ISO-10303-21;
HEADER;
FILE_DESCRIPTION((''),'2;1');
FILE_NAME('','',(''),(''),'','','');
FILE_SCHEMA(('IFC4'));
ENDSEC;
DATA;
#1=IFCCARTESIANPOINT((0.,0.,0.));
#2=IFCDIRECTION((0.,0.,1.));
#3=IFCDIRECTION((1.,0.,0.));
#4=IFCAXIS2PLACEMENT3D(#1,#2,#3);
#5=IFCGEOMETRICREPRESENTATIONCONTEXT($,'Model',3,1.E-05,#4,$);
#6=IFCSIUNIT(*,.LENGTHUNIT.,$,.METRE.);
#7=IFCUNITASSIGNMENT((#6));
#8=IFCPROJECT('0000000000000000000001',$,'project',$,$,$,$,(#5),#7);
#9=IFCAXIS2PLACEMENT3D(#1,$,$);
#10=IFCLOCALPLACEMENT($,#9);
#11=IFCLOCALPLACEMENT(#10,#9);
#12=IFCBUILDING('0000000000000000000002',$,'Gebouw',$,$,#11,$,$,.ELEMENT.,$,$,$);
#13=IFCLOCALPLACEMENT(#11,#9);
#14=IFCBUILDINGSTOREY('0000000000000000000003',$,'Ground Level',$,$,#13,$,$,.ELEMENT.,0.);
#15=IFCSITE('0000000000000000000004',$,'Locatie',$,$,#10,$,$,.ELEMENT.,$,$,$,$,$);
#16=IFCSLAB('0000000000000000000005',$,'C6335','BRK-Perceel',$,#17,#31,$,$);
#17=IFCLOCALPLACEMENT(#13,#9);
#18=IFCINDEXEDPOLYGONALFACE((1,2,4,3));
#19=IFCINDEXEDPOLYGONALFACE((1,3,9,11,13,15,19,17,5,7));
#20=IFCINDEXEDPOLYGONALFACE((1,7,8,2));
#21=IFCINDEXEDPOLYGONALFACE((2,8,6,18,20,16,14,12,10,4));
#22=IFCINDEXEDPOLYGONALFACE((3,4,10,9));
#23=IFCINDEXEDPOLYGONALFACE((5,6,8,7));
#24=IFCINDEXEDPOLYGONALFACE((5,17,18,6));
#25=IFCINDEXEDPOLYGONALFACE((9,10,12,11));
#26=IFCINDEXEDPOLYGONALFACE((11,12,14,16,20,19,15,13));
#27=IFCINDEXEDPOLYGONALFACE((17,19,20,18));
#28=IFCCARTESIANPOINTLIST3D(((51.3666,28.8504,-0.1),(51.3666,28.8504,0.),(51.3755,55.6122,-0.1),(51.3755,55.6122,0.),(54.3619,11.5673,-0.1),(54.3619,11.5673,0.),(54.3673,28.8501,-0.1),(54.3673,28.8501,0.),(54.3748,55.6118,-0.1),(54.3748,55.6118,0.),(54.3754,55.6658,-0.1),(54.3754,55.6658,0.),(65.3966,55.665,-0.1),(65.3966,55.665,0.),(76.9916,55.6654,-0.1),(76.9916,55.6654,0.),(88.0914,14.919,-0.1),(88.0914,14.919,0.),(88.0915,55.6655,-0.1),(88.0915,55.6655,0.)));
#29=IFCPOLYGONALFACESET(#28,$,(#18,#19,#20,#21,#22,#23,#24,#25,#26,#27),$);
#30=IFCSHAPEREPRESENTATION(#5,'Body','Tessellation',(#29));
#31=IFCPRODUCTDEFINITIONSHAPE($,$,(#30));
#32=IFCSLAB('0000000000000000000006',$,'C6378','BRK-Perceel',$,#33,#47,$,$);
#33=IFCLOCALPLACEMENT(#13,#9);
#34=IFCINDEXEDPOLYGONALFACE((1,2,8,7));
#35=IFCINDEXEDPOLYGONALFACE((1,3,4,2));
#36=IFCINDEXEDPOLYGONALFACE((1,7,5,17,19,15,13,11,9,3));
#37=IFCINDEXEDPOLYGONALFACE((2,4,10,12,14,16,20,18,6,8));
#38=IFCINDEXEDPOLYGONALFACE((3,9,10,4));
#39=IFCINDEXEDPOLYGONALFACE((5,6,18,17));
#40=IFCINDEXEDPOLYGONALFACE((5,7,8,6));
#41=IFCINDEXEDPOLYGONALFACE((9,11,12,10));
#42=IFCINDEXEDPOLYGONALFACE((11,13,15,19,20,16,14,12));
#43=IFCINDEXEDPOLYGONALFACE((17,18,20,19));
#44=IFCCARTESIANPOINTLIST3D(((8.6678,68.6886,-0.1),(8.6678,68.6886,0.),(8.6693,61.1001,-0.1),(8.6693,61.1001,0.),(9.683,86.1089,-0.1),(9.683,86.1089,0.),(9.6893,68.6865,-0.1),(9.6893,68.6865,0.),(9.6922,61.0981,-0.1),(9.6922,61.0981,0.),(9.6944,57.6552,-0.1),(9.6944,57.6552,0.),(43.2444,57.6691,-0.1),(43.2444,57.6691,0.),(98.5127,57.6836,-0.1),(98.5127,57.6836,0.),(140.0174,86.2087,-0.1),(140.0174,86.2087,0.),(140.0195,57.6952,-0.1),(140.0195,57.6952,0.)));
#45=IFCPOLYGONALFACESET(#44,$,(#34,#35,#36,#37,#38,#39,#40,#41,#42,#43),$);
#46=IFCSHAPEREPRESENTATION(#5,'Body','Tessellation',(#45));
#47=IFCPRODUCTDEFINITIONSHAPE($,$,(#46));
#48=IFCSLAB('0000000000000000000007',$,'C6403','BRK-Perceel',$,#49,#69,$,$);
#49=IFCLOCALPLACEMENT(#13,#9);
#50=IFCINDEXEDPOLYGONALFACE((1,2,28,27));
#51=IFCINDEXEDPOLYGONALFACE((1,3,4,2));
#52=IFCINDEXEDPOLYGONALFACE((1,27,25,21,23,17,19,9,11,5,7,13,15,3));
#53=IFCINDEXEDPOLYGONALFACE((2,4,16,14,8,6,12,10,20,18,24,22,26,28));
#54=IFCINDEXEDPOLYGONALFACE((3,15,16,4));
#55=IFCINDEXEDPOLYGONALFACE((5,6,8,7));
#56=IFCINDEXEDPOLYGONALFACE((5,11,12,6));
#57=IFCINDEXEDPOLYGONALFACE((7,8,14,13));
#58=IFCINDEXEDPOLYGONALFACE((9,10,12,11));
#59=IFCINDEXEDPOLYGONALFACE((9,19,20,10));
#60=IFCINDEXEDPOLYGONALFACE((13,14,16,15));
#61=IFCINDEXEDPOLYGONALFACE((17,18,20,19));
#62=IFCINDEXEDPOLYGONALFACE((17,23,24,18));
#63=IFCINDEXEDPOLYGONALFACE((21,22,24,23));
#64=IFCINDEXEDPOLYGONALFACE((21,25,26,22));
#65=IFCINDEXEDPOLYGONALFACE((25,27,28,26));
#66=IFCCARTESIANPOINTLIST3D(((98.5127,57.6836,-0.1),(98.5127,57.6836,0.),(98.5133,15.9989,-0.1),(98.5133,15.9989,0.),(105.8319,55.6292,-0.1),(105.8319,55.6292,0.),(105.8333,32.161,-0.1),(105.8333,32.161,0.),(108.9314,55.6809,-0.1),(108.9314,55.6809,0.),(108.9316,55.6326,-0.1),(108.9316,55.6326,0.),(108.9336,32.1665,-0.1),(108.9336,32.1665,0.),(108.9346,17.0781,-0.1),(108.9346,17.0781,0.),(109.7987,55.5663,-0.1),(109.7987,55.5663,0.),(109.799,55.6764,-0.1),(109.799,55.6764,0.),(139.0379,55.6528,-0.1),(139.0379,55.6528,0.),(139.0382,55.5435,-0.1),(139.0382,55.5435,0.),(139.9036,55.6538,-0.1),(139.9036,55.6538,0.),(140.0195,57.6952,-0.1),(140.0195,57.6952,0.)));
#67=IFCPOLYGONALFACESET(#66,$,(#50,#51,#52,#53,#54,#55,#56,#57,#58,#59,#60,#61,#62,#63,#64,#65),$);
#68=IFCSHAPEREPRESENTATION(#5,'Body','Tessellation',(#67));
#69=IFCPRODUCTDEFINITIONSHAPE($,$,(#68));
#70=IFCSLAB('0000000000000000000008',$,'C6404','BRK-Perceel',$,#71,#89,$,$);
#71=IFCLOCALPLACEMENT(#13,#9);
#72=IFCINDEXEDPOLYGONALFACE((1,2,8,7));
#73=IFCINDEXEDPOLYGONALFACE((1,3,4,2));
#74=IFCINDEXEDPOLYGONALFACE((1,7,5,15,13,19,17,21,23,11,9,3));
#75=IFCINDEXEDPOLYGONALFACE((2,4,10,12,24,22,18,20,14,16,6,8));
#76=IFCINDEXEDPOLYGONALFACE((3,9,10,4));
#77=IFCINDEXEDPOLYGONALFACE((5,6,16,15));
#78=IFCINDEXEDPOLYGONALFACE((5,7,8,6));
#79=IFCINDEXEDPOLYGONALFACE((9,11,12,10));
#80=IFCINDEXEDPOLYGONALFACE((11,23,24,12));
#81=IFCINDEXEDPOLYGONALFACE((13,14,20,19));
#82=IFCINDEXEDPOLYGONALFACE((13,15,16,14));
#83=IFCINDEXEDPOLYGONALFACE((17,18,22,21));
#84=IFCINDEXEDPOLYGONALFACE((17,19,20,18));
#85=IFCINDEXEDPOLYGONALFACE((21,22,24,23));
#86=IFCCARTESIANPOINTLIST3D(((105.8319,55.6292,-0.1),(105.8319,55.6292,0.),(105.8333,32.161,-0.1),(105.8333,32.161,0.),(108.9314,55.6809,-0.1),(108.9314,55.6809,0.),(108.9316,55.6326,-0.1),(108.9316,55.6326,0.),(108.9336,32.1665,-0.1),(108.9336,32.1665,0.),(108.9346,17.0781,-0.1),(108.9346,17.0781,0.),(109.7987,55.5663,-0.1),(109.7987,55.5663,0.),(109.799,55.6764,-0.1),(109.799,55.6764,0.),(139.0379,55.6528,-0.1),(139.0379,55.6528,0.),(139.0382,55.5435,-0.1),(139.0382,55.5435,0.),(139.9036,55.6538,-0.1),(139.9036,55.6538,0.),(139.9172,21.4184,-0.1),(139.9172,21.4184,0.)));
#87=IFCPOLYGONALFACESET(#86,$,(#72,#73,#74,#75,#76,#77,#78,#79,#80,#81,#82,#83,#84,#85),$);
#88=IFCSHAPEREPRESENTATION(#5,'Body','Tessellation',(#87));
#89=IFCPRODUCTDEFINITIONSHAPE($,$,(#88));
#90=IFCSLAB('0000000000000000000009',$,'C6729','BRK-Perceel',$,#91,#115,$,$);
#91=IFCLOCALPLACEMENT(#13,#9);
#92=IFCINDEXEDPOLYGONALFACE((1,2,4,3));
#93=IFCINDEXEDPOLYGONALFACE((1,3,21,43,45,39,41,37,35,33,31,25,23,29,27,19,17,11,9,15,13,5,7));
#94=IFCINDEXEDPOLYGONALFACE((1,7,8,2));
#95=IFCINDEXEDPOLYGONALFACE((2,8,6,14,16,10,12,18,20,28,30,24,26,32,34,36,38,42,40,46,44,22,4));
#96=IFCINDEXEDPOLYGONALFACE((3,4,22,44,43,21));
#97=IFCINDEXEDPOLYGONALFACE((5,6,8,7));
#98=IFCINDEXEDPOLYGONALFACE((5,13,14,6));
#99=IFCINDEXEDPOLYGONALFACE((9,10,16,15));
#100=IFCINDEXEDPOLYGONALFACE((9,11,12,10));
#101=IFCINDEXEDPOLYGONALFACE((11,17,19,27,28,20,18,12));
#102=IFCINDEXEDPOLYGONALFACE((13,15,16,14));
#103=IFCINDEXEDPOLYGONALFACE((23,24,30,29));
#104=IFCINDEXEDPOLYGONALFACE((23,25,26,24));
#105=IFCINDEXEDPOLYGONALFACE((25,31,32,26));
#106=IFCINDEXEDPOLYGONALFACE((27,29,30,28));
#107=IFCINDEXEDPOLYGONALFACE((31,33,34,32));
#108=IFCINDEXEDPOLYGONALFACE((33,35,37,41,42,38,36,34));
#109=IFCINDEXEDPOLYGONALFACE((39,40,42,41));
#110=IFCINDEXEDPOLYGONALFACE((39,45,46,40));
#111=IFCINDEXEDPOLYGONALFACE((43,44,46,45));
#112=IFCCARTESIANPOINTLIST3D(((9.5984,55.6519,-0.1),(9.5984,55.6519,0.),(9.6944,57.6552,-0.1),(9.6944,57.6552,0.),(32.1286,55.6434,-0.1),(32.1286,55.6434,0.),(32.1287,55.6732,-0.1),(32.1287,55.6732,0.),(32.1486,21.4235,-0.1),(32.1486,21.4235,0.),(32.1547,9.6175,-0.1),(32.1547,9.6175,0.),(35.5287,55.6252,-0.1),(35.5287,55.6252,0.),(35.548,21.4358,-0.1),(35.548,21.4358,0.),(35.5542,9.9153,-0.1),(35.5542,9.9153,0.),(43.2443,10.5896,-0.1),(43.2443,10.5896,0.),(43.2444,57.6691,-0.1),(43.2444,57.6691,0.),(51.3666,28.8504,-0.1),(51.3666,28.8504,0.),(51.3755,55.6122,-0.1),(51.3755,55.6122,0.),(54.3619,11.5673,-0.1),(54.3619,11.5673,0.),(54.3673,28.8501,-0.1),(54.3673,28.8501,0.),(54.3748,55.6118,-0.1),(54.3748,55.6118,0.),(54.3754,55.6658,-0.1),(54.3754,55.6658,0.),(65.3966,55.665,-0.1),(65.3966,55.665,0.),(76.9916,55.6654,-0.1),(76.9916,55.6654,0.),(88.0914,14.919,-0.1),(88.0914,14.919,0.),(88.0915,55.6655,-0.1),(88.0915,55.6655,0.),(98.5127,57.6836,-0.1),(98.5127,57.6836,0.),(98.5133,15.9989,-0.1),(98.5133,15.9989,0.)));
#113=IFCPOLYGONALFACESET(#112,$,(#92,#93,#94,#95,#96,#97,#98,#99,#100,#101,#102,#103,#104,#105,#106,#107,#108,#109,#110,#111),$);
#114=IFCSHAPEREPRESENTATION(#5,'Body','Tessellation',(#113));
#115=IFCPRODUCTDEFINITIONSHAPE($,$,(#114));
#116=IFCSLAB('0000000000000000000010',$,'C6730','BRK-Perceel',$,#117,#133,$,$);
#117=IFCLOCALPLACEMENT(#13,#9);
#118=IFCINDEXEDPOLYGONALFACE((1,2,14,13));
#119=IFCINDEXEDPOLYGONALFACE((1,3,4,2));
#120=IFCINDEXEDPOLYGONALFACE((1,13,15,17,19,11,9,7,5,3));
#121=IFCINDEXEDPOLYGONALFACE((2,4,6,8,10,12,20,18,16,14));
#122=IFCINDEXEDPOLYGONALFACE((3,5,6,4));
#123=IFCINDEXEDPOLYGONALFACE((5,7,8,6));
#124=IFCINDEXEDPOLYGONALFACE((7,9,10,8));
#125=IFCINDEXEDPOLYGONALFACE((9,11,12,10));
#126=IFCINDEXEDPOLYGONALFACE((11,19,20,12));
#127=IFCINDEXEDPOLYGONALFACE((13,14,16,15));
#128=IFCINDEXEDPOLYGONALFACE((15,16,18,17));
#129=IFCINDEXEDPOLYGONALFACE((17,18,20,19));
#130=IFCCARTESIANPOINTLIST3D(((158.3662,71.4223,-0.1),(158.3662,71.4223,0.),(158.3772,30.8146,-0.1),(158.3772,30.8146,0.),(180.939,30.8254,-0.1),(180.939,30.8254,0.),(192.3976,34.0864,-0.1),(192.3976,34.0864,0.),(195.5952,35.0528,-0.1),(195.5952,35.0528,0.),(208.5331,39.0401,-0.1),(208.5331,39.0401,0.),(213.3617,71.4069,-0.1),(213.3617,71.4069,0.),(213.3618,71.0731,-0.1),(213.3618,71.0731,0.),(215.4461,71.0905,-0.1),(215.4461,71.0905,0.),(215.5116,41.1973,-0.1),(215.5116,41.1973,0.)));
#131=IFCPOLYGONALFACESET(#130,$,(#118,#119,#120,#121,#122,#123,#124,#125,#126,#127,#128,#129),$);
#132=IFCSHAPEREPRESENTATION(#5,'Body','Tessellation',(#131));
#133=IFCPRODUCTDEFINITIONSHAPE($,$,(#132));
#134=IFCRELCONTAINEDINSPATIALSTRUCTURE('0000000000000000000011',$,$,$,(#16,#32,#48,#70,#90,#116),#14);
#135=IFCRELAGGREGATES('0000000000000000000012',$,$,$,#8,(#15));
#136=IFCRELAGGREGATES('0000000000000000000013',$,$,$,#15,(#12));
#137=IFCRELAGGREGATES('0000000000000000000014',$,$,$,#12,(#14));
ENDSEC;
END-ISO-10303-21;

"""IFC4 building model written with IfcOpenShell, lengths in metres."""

from ifc_helpers import new_model, si_unit, frame, origin, origin_with_axes, place, context, project, spatial, polyline, outline, extrude, element, save


model = new_model("IFC4")

# Units and contexts
model_context = context("Model", 3, precision=1e-05, world=origin_with_axes())
ifc_project = project(units=[si_unit("LENGTHUNIT", "METRE")], contexts=[model_context])

# Site, building, storey
site_placement = place(None, origin())
site = spatial("IfcSite", under=ifc_project, at=site_placement, Name="Locatie", CompositionType="ELEMENT")
building_placement = place(site_placement, origin())
building = spatial("IfcBuilding", under=site, at=building_placement, Name="Gebouw", CompositionType="ELEMENT")
storey_placement = place(building_placement, origin())
storey = spatial("IfcBuildingStorey", under=building, at=storey_placement, Name="Ground Level", CompositionType="ELEMENT", Elevation=0.0)

# Slabs
slab_1_placement = place(storey_placement, origin())
element("IfcSlab", 1, at=slab_1_placement, inside=storey, Name="C6335", Description="BRK-Perceel", context=model_context, shape_type="SweptSolid", body=[
    extrude(outline(polyline([(54.3748, 55.6118), (54.3754, 55.6658), (65.3966, 55.665), (76.9916, 55.6654), (88.0915, 55.6655), (88.0914, 14.919), (54.3619, 11.5673), (54.3673, 28.8501), (51.3666, 28.8504), (51.3755, 55.6122), (54.3748, 55.6118)])), frame((0.0, 0.0, -0.1), z_axis=(0.0, 0.0, 1.0), x_axis=(1.0, 0.0, 0.0)), (0.0, 0.0, 1.0), 0.1),
])
slab_2_placement = place(storey_placement, origin())
element("IfcSlab", 2, at=slab_2_placement, inside=storey, Name="C6378", Description="BRK-Perceel", context=model_context, shape_type="SweptSolid", body=[
    extrude(outline(polyline([(98.5127, 57.6836), (43.2444, 57.6691), (9.6944, 57.6552), (9.6922, 61.0981), (8.6693, 61.1001), (8.6678, 68.6886), (9.6893, 68.6865), (9.683, 86.1089), (140.0174, 86.2087), (140.0195, 57.6952), (98.5127, 57.6836)])), frame((0.0, 0.0, -0.1), z_axis=(0.0, 0.0, 1.0), x_axis=(1.0, 0.0, 0.0)), (0.0, 0.0, 1.0), 0.1),
])
slab_3_placement = place(storey_placement, origin())
element("IfcSlab", 3, at=slab_3_placement, inside=storey, Name="C6403", Description="BRK-Perceel", context=model_context, shape_type="SweptSolid", body=[
    extrude(outline(polyline([(98.5133, 15.9989), (98.5127, 57.6836), (140.0195, 57.6952), (139.9036, 55.6538), (139.0379, 55.6528), (139.0382, 55.5435), (109.7987, 55.5663), (109.799, 55.6764), (108.9314, 55.6809), (108.9316, 55.6326), (105.8319, 55.6292), (105.8333, 32.161), (108.9336, 32.1665), (108.9346, 17.0781), (98.5133, 15.9989)])), frame((0.0, 0.0, -0.1), z_axis=(0.0, 0.0, 1.0), x_axis=(1.0, 0.0, 0.0)), (0.0, 0.0, 1.0), 0.1),
])
slab_4_placement = place(storey_placement, origin())
element("IfcSlab", 4, at=slab_4_placement, inside=storey, Name="C6404", Description="BRK-Perceel", context=model_context, shape_type="SweptSolid", body=[
    extrude(outline(polyline([(108.9314, 55.6809), (109.799, 55.6764), (109.7987, 55.5663), (139.0382, 55.5435), (139.0379, 55.6528), (139.9036, 55.6538), (139.9172, 21.4184), (108.9346, 17.0781), (108.9336, 32.1665), (105.8333, 32.161), (105.8319, 55.6292), (108.9316, 55.6326), (108.9314, 55.6809)])), frame((0.0, 0.0, -0.1), z_axis=(0.0, 0.0, 1.0), x_axis=(1.0, 0.0, 0.0)), (0.0, 0.0, 1.0), 0.1),
])
slab_5_placement = place(storey_placement, origin())
element("IfcSlab", 5, at=slab_5_placement, inside=storey, Name="C6729", Description="BRK-Perceel", context=model_context, shape_type="SweptSolid", body=[
    extrude(outline(polyline([(43.2443, 10.5896), (35.5542, 9.9153), (32.1547, 9.6175), (32.1486, 21.4235), (35.548, 21.4358), (35.5287, 55.6252), (32.1286, 55.6434), (32.1287, 55.6732), (9.5984, 55.6519), (9.6944, 57.6552), (43.2444, 57.6691), (98.5127, 57.6836), (98.5133, 15.9989), (88.0914, 14.919), (88.0915, 55.6655), (76.9916, 55.6654), (65.3966, 55.665), (54.3754, 55.6658), (54.3748, 55.6118), (51.3755, 55.6122), (51.3666, 28.8504), (54.3673, 28.8501), (54.3619, 11.5673), (43.2443, 10.5896)])), frame((0.0, 0.0, -0.1), z_axis=(0.0, 0.0, 1.0), x_axis=(1.0, 0.0, 0.0)), (0.0, 0.0, 1.0), 0.1),
])
slab_6_placement = place(storey_placement, origin())
element("IfcSlab", 6, at=slab_6_placement, inside=storey, Name="C6730", Description="BRK-Perceel", context=model_context, shape_type="SweptSolid", body=[
    extrude(outline(polyline([(215.4461, 71.0905), (215.5116, 41.1973), (208.5331, 39.0401), (195.5952, 35.0528), (192.3976, 34.0864), (180.939, 30.8254), (158.3772, 30.8146), (158.3662, 71.4223), (213.3617, 71.4069), (213.3618, 71.0731), (215.4461, 71.0905)])), frame((0.0, 0.0, -0.1), z_axis=(0.0, 0.0, 1.0), x_axis=(1.0, 0.0, 0.0)), (0.0, 0.0, 1.0), 0.1),
])

save(model, "model.ifc")
